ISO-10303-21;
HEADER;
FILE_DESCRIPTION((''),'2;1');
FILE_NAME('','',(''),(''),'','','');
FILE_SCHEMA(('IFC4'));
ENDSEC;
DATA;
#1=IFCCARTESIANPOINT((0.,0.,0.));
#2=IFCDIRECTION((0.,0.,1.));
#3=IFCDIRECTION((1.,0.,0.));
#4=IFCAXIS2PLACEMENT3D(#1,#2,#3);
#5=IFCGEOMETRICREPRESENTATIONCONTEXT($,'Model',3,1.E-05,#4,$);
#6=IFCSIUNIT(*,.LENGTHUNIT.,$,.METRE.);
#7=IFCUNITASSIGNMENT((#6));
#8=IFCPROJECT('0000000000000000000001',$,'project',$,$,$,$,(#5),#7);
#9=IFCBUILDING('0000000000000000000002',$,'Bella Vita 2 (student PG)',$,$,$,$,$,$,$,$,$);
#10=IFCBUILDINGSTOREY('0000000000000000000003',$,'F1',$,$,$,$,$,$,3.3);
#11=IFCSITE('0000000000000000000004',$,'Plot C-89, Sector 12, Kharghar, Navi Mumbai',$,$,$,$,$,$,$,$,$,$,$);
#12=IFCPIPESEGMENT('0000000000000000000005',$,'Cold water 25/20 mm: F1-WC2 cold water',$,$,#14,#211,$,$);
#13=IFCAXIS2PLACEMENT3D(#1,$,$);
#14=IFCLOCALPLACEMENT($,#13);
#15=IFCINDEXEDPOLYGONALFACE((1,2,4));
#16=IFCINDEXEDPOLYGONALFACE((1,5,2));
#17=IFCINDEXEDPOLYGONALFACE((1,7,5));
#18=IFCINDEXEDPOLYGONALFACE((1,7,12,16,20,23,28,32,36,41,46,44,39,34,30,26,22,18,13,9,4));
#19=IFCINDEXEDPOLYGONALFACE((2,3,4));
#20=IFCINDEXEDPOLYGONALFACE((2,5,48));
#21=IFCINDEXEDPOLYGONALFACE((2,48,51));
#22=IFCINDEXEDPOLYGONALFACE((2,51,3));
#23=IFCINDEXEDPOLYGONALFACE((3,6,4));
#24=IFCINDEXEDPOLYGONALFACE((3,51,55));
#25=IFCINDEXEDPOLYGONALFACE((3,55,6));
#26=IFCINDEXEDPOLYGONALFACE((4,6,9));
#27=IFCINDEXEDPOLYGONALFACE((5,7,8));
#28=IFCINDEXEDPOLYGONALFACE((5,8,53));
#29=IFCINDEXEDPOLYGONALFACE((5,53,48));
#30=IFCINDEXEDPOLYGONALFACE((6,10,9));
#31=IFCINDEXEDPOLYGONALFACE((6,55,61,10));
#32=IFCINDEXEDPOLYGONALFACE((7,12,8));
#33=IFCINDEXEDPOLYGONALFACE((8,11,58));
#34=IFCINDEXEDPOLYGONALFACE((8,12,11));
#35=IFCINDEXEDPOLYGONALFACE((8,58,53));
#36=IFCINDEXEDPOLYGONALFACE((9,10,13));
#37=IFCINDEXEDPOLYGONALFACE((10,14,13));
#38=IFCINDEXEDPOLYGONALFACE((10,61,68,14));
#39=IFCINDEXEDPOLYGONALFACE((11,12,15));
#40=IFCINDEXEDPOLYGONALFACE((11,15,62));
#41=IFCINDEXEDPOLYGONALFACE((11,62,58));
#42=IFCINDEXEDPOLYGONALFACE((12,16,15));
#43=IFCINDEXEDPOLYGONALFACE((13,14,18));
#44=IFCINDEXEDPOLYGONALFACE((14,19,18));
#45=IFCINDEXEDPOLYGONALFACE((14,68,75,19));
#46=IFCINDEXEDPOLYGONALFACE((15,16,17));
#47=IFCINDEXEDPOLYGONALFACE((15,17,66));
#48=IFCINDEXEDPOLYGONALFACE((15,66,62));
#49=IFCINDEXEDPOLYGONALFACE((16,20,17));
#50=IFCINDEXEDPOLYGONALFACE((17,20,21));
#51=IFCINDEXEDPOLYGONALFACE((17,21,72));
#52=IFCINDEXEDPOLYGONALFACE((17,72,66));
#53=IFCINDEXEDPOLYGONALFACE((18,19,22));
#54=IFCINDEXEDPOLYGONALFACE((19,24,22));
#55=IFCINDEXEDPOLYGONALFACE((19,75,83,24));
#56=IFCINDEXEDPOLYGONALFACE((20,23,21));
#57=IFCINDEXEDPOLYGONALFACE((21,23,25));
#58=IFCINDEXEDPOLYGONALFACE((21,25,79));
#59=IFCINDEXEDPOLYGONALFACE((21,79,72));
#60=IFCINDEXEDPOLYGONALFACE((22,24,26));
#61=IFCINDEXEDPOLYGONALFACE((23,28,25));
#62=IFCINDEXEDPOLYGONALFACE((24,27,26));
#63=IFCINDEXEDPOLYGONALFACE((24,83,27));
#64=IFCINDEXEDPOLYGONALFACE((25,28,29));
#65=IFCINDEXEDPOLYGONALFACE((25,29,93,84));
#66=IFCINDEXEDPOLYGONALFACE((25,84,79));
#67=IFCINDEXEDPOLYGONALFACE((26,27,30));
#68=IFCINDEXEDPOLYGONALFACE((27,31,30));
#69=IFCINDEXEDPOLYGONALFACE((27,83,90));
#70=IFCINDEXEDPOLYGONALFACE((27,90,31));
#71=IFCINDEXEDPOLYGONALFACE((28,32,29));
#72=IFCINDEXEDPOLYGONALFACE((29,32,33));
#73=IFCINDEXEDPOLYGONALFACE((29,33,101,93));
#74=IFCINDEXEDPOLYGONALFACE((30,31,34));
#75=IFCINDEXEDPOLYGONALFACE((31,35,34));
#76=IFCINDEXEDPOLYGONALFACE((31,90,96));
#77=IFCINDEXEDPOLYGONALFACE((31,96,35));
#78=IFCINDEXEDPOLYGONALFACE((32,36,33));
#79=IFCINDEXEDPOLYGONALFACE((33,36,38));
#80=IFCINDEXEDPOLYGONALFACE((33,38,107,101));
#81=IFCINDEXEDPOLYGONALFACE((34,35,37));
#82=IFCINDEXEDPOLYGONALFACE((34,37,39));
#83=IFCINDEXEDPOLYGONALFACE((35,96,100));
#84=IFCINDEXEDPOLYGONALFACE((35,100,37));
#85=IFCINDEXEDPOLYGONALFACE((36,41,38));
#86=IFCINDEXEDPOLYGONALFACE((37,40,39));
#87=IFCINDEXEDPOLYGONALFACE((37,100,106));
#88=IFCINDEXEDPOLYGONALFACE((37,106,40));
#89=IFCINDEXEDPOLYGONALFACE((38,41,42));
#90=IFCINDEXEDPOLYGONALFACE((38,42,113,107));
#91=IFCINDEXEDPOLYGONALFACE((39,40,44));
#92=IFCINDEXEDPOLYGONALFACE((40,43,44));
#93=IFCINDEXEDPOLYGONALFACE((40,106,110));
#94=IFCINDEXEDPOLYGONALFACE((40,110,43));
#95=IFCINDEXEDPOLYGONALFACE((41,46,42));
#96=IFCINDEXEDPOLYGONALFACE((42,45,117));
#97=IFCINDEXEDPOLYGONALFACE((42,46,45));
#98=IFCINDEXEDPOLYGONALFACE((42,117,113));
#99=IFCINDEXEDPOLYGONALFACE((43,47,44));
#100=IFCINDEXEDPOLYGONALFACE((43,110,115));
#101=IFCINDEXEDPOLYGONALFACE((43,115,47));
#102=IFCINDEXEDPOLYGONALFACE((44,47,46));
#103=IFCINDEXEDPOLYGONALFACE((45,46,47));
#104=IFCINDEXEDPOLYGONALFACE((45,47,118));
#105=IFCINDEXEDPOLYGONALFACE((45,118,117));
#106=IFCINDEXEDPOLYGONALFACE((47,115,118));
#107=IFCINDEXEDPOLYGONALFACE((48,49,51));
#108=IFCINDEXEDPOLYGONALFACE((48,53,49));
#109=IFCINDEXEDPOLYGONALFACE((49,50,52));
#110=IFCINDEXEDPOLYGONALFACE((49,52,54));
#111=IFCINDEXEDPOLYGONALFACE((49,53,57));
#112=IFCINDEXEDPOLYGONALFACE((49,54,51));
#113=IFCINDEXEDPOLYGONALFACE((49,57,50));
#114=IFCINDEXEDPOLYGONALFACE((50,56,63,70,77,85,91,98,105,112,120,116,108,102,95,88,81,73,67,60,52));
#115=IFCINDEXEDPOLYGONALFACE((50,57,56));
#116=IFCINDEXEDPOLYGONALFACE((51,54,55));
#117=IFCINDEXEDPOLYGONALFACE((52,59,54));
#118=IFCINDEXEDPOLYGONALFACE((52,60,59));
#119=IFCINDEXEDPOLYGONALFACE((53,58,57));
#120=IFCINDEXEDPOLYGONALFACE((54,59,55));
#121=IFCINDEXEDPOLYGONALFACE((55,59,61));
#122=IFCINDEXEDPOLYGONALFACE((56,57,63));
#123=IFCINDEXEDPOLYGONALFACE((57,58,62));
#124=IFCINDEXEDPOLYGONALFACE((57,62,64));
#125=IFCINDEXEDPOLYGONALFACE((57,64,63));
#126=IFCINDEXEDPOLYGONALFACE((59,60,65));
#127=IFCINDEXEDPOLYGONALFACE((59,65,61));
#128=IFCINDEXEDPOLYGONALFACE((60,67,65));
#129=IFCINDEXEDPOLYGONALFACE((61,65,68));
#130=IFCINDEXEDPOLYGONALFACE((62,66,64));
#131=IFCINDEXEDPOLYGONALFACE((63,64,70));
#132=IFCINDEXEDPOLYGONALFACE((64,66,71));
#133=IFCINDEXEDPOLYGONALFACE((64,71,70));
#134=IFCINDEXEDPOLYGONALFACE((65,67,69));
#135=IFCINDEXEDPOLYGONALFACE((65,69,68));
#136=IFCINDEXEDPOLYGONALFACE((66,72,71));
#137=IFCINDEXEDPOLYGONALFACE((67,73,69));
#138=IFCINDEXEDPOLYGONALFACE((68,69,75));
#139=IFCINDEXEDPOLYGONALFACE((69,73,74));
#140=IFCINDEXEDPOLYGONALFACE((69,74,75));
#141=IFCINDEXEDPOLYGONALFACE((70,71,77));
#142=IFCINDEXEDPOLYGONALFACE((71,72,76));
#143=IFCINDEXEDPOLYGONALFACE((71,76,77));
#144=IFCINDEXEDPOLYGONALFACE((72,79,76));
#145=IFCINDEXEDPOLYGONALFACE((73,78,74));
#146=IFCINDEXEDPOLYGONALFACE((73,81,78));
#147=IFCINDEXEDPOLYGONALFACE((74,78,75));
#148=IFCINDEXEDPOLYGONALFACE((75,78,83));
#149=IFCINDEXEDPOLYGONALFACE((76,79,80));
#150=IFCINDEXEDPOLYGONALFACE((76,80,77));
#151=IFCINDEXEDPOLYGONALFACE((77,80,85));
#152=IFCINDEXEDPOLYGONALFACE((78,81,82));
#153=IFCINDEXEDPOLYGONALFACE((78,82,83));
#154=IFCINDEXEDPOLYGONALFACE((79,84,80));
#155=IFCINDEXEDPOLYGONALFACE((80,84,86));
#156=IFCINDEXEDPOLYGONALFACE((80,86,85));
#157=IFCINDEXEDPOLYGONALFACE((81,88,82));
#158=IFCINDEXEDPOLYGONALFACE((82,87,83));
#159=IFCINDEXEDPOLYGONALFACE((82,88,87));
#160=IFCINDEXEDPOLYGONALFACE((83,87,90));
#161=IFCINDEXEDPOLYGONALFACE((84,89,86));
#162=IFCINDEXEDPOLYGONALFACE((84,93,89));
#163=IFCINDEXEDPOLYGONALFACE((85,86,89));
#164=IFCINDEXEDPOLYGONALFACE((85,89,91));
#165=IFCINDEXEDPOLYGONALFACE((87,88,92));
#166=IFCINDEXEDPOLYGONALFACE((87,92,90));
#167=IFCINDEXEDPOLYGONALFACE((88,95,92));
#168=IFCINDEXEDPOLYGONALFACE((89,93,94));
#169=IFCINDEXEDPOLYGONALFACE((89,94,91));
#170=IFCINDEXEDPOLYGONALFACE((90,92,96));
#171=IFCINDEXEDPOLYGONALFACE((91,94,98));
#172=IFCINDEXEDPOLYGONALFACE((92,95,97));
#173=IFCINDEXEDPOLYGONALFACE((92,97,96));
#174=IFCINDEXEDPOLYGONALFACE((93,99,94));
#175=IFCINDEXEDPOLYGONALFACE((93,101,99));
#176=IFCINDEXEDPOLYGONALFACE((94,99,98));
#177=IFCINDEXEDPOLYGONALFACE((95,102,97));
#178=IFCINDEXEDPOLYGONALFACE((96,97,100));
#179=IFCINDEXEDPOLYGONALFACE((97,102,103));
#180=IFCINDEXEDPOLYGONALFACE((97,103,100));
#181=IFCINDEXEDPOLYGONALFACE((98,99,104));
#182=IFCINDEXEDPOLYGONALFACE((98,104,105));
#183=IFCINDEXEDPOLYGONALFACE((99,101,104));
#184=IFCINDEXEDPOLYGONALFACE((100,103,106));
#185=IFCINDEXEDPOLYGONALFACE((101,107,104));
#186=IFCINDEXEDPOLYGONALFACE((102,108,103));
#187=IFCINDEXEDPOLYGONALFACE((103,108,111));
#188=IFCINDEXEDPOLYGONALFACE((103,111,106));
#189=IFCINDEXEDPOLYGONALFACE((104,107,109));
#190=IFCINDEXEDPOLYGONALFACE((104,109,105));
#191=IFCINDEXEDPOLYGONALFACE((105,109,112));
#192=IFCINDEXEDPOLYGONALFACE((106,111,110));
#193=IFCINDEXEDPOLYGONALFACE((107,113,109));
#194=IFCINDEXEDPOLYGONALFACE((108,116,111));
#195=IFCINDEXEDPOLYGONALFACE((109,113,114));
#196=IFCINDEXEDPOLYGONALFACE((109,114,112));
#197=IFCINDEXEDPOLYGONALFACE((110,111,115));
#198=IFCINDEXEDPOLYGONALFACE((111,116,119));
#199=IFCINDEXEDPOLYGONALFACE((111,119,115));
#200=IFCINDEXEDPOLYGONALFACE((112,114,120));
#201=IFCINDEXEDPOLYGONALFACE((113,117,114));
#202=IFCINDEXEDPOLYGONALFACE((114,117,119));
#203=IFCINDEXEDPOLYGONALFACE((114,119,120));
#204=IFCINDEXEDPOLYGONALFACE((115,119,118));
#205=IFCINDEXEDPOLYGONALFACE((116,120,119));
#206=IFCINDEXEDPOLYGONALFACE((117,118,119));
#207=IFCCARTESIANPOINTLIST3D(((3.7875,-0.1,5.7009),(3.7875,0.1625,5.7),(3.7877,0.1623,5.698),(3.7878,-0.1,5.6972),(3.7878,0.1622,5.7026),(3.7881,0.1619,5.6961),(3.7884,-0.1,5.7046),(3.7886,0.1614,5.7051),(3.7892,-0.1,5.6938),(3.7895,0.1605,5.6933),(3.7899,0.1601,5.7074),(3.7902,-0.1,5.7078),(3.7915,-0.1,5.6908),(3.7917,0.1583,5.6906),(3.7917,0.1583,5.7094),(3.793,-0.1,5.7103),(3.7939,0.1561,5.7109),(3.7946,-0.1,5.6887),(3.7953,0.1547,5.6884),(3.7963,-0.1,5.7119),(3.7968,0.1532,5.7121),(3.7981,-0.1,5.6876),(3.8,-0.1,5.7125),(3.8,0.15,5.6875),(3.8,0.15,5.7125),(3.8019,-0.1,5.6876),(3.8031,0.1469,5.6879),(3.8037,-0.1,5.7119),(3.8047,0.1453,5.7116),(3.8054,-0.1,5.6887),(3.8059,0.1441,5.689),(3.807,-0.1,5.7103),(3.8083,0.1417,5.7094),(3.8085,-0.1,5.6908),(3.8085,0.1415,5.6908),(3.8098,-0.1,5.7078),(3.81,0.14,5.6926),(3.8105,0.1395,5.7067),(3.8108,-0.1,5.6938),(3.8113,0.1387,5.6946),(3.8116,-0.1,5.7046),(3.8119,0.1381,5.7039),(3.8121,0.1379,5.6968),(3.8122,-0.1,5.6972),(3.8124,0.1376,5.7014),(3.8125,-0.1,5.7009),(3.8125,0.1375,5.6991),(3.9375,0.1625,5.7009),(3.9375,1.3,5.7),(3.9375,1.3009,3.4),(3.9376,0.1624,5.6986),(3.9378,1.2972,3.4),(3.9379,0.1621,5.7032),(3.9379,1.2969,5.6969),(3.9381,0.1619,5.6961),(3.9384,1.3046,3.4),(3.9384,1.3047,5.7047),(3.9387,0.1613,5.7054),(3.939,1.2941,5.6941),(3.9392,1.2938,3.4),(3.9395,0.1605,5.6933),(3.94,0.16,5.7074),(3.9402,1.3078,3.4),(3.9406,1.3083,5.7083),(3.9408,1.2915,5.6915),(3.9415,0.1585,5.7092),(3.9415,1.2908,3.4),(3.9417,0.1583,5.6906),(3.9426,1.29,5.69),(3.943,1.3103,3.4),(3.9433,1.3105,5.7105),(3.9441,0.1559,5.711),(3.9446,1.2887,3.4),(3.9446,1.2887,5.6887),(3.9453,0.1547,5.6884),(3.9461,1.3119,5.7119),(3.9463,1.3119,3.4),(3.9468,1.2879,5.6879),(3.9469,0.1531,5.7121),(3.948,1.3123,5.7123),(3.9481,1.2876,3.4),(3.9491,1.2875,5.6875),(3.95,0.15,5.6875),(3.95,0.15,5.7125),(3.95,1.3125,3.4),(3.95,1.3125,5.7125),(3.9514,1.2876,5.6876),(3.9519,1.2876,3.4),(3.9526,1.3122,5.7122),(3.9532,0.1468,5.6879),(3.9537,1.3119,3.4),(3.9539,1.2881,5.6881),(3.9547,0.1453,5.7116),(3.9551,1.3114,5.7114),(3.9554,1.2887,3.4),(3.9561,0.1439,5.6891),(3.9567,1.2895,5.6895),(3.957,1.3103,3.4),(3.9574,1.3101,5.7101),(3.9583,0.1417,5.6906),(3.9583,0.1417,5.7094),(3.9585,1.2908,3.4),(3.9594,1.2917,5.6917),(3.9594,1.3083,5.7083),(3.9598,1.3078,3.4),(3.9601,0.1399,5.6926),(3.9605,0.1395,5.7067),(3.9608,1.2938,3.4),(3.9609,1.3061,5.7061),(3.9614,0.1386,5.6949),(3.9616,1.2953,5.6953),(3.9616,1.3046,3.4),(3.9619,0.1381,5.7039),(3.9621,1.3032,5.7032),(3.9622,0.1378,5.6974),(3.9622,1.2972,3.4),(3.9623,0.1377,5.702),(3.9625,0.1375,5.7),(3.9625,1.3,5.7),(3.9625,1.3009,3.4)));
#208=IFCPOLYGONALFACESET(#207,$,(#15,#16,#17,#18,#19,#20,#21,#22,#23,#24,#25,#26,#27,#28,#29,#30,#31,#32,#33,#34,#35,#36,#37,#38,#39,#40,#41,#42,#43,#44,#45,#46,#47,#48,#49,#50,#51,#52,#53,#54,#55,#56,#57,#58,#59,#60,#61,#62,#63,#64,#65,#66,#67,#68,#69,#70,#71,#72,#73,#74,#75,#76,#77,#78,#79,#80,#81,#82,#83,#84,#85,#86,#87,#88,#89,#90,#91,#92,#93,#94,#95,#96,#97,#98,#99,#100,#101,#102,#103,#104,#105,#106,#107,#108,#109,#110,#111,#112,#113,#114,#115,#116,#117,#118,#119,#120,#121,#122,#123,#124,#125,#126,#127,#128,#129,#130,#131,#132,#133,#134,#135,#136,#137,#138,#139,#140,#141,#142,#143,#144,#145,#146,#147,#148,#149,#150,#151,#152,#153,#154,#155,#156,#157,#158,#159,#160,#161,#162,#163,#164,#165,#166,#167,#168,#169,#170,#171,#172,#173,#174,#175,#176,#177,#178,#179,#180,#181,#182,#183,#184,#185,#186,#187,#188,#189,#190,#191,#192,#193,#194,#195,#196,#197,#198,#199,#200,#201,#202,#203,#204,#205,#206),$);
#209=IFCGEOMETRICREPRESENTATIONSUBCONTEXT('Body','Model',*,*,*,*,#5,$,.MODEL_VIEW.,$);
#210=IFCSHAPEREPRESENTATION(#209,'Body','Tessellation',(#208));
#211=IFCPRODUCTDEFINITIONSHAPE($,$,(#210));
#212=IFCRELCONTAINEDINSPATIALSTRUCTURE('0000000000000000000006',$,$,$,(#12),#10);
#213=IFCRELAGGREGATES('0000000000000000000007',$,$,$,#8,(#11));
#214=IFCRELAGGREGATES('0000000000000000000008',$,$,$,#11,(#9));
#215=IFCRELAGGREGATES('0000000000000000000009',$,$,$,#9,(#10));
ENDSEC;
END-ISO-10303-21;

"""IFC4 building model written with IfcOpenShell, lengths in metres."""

from ifc_helpers import new_model, entity, si_unit, origin, origin_with_axes, place, context, subcontext, project, spatial, element, save


model = new_model("IFC4")

# Units and contexts
model_context = context("Model", 3, precision=1e-05, world=origin_with_axes())
body_context = subcontext(model_context, "Body", "Model", "MODEL_VIEW")
ifc_project = project(units=[si_unit("LENGTHUNIT", "METRE")], contexts=[model_context])

# Site, building, storey
site = spatial("IfcSite", under=ifc_project, Name="Plot C-89, Sector 12, Kharghar, Navi Mumbai")
building = spatial("IfcBuilding", under=site, Name="Bella Vita 2 (student PG)")
storey = spatial("IfcBuildingStorey", under=building, Name="F1", Elevation=3.3)

# Pipe segment
pipe_segment_1_placement = place(None, origin())
element("IfcPipeSegment", 1, at=pipe_segment_1_placement, inside=storey, Name="Cold water 25/20 mm: F1-WC2 cold water", context=body_context, shape_type="AdvancedSweptSolid", body=[
    entity("IfcSweptDiskSolid", entity("IfcPolyline", [entity("IfcCartesianPoint", [3.8, -0.1, 5.7]), entity("IfcCartesianPoint", [3.8, 0.15, 5.7]), entity("IfcCartesianPoint", [3.95, 0.15, 5.7]), entity("IfcCartesianPoint", [3.95, 1.3, 5.7]), entity("IfcCartesianPoint", [3.95, 1.3, 3.4])]), 0.0125),
])

save(model, "model.ifc")
